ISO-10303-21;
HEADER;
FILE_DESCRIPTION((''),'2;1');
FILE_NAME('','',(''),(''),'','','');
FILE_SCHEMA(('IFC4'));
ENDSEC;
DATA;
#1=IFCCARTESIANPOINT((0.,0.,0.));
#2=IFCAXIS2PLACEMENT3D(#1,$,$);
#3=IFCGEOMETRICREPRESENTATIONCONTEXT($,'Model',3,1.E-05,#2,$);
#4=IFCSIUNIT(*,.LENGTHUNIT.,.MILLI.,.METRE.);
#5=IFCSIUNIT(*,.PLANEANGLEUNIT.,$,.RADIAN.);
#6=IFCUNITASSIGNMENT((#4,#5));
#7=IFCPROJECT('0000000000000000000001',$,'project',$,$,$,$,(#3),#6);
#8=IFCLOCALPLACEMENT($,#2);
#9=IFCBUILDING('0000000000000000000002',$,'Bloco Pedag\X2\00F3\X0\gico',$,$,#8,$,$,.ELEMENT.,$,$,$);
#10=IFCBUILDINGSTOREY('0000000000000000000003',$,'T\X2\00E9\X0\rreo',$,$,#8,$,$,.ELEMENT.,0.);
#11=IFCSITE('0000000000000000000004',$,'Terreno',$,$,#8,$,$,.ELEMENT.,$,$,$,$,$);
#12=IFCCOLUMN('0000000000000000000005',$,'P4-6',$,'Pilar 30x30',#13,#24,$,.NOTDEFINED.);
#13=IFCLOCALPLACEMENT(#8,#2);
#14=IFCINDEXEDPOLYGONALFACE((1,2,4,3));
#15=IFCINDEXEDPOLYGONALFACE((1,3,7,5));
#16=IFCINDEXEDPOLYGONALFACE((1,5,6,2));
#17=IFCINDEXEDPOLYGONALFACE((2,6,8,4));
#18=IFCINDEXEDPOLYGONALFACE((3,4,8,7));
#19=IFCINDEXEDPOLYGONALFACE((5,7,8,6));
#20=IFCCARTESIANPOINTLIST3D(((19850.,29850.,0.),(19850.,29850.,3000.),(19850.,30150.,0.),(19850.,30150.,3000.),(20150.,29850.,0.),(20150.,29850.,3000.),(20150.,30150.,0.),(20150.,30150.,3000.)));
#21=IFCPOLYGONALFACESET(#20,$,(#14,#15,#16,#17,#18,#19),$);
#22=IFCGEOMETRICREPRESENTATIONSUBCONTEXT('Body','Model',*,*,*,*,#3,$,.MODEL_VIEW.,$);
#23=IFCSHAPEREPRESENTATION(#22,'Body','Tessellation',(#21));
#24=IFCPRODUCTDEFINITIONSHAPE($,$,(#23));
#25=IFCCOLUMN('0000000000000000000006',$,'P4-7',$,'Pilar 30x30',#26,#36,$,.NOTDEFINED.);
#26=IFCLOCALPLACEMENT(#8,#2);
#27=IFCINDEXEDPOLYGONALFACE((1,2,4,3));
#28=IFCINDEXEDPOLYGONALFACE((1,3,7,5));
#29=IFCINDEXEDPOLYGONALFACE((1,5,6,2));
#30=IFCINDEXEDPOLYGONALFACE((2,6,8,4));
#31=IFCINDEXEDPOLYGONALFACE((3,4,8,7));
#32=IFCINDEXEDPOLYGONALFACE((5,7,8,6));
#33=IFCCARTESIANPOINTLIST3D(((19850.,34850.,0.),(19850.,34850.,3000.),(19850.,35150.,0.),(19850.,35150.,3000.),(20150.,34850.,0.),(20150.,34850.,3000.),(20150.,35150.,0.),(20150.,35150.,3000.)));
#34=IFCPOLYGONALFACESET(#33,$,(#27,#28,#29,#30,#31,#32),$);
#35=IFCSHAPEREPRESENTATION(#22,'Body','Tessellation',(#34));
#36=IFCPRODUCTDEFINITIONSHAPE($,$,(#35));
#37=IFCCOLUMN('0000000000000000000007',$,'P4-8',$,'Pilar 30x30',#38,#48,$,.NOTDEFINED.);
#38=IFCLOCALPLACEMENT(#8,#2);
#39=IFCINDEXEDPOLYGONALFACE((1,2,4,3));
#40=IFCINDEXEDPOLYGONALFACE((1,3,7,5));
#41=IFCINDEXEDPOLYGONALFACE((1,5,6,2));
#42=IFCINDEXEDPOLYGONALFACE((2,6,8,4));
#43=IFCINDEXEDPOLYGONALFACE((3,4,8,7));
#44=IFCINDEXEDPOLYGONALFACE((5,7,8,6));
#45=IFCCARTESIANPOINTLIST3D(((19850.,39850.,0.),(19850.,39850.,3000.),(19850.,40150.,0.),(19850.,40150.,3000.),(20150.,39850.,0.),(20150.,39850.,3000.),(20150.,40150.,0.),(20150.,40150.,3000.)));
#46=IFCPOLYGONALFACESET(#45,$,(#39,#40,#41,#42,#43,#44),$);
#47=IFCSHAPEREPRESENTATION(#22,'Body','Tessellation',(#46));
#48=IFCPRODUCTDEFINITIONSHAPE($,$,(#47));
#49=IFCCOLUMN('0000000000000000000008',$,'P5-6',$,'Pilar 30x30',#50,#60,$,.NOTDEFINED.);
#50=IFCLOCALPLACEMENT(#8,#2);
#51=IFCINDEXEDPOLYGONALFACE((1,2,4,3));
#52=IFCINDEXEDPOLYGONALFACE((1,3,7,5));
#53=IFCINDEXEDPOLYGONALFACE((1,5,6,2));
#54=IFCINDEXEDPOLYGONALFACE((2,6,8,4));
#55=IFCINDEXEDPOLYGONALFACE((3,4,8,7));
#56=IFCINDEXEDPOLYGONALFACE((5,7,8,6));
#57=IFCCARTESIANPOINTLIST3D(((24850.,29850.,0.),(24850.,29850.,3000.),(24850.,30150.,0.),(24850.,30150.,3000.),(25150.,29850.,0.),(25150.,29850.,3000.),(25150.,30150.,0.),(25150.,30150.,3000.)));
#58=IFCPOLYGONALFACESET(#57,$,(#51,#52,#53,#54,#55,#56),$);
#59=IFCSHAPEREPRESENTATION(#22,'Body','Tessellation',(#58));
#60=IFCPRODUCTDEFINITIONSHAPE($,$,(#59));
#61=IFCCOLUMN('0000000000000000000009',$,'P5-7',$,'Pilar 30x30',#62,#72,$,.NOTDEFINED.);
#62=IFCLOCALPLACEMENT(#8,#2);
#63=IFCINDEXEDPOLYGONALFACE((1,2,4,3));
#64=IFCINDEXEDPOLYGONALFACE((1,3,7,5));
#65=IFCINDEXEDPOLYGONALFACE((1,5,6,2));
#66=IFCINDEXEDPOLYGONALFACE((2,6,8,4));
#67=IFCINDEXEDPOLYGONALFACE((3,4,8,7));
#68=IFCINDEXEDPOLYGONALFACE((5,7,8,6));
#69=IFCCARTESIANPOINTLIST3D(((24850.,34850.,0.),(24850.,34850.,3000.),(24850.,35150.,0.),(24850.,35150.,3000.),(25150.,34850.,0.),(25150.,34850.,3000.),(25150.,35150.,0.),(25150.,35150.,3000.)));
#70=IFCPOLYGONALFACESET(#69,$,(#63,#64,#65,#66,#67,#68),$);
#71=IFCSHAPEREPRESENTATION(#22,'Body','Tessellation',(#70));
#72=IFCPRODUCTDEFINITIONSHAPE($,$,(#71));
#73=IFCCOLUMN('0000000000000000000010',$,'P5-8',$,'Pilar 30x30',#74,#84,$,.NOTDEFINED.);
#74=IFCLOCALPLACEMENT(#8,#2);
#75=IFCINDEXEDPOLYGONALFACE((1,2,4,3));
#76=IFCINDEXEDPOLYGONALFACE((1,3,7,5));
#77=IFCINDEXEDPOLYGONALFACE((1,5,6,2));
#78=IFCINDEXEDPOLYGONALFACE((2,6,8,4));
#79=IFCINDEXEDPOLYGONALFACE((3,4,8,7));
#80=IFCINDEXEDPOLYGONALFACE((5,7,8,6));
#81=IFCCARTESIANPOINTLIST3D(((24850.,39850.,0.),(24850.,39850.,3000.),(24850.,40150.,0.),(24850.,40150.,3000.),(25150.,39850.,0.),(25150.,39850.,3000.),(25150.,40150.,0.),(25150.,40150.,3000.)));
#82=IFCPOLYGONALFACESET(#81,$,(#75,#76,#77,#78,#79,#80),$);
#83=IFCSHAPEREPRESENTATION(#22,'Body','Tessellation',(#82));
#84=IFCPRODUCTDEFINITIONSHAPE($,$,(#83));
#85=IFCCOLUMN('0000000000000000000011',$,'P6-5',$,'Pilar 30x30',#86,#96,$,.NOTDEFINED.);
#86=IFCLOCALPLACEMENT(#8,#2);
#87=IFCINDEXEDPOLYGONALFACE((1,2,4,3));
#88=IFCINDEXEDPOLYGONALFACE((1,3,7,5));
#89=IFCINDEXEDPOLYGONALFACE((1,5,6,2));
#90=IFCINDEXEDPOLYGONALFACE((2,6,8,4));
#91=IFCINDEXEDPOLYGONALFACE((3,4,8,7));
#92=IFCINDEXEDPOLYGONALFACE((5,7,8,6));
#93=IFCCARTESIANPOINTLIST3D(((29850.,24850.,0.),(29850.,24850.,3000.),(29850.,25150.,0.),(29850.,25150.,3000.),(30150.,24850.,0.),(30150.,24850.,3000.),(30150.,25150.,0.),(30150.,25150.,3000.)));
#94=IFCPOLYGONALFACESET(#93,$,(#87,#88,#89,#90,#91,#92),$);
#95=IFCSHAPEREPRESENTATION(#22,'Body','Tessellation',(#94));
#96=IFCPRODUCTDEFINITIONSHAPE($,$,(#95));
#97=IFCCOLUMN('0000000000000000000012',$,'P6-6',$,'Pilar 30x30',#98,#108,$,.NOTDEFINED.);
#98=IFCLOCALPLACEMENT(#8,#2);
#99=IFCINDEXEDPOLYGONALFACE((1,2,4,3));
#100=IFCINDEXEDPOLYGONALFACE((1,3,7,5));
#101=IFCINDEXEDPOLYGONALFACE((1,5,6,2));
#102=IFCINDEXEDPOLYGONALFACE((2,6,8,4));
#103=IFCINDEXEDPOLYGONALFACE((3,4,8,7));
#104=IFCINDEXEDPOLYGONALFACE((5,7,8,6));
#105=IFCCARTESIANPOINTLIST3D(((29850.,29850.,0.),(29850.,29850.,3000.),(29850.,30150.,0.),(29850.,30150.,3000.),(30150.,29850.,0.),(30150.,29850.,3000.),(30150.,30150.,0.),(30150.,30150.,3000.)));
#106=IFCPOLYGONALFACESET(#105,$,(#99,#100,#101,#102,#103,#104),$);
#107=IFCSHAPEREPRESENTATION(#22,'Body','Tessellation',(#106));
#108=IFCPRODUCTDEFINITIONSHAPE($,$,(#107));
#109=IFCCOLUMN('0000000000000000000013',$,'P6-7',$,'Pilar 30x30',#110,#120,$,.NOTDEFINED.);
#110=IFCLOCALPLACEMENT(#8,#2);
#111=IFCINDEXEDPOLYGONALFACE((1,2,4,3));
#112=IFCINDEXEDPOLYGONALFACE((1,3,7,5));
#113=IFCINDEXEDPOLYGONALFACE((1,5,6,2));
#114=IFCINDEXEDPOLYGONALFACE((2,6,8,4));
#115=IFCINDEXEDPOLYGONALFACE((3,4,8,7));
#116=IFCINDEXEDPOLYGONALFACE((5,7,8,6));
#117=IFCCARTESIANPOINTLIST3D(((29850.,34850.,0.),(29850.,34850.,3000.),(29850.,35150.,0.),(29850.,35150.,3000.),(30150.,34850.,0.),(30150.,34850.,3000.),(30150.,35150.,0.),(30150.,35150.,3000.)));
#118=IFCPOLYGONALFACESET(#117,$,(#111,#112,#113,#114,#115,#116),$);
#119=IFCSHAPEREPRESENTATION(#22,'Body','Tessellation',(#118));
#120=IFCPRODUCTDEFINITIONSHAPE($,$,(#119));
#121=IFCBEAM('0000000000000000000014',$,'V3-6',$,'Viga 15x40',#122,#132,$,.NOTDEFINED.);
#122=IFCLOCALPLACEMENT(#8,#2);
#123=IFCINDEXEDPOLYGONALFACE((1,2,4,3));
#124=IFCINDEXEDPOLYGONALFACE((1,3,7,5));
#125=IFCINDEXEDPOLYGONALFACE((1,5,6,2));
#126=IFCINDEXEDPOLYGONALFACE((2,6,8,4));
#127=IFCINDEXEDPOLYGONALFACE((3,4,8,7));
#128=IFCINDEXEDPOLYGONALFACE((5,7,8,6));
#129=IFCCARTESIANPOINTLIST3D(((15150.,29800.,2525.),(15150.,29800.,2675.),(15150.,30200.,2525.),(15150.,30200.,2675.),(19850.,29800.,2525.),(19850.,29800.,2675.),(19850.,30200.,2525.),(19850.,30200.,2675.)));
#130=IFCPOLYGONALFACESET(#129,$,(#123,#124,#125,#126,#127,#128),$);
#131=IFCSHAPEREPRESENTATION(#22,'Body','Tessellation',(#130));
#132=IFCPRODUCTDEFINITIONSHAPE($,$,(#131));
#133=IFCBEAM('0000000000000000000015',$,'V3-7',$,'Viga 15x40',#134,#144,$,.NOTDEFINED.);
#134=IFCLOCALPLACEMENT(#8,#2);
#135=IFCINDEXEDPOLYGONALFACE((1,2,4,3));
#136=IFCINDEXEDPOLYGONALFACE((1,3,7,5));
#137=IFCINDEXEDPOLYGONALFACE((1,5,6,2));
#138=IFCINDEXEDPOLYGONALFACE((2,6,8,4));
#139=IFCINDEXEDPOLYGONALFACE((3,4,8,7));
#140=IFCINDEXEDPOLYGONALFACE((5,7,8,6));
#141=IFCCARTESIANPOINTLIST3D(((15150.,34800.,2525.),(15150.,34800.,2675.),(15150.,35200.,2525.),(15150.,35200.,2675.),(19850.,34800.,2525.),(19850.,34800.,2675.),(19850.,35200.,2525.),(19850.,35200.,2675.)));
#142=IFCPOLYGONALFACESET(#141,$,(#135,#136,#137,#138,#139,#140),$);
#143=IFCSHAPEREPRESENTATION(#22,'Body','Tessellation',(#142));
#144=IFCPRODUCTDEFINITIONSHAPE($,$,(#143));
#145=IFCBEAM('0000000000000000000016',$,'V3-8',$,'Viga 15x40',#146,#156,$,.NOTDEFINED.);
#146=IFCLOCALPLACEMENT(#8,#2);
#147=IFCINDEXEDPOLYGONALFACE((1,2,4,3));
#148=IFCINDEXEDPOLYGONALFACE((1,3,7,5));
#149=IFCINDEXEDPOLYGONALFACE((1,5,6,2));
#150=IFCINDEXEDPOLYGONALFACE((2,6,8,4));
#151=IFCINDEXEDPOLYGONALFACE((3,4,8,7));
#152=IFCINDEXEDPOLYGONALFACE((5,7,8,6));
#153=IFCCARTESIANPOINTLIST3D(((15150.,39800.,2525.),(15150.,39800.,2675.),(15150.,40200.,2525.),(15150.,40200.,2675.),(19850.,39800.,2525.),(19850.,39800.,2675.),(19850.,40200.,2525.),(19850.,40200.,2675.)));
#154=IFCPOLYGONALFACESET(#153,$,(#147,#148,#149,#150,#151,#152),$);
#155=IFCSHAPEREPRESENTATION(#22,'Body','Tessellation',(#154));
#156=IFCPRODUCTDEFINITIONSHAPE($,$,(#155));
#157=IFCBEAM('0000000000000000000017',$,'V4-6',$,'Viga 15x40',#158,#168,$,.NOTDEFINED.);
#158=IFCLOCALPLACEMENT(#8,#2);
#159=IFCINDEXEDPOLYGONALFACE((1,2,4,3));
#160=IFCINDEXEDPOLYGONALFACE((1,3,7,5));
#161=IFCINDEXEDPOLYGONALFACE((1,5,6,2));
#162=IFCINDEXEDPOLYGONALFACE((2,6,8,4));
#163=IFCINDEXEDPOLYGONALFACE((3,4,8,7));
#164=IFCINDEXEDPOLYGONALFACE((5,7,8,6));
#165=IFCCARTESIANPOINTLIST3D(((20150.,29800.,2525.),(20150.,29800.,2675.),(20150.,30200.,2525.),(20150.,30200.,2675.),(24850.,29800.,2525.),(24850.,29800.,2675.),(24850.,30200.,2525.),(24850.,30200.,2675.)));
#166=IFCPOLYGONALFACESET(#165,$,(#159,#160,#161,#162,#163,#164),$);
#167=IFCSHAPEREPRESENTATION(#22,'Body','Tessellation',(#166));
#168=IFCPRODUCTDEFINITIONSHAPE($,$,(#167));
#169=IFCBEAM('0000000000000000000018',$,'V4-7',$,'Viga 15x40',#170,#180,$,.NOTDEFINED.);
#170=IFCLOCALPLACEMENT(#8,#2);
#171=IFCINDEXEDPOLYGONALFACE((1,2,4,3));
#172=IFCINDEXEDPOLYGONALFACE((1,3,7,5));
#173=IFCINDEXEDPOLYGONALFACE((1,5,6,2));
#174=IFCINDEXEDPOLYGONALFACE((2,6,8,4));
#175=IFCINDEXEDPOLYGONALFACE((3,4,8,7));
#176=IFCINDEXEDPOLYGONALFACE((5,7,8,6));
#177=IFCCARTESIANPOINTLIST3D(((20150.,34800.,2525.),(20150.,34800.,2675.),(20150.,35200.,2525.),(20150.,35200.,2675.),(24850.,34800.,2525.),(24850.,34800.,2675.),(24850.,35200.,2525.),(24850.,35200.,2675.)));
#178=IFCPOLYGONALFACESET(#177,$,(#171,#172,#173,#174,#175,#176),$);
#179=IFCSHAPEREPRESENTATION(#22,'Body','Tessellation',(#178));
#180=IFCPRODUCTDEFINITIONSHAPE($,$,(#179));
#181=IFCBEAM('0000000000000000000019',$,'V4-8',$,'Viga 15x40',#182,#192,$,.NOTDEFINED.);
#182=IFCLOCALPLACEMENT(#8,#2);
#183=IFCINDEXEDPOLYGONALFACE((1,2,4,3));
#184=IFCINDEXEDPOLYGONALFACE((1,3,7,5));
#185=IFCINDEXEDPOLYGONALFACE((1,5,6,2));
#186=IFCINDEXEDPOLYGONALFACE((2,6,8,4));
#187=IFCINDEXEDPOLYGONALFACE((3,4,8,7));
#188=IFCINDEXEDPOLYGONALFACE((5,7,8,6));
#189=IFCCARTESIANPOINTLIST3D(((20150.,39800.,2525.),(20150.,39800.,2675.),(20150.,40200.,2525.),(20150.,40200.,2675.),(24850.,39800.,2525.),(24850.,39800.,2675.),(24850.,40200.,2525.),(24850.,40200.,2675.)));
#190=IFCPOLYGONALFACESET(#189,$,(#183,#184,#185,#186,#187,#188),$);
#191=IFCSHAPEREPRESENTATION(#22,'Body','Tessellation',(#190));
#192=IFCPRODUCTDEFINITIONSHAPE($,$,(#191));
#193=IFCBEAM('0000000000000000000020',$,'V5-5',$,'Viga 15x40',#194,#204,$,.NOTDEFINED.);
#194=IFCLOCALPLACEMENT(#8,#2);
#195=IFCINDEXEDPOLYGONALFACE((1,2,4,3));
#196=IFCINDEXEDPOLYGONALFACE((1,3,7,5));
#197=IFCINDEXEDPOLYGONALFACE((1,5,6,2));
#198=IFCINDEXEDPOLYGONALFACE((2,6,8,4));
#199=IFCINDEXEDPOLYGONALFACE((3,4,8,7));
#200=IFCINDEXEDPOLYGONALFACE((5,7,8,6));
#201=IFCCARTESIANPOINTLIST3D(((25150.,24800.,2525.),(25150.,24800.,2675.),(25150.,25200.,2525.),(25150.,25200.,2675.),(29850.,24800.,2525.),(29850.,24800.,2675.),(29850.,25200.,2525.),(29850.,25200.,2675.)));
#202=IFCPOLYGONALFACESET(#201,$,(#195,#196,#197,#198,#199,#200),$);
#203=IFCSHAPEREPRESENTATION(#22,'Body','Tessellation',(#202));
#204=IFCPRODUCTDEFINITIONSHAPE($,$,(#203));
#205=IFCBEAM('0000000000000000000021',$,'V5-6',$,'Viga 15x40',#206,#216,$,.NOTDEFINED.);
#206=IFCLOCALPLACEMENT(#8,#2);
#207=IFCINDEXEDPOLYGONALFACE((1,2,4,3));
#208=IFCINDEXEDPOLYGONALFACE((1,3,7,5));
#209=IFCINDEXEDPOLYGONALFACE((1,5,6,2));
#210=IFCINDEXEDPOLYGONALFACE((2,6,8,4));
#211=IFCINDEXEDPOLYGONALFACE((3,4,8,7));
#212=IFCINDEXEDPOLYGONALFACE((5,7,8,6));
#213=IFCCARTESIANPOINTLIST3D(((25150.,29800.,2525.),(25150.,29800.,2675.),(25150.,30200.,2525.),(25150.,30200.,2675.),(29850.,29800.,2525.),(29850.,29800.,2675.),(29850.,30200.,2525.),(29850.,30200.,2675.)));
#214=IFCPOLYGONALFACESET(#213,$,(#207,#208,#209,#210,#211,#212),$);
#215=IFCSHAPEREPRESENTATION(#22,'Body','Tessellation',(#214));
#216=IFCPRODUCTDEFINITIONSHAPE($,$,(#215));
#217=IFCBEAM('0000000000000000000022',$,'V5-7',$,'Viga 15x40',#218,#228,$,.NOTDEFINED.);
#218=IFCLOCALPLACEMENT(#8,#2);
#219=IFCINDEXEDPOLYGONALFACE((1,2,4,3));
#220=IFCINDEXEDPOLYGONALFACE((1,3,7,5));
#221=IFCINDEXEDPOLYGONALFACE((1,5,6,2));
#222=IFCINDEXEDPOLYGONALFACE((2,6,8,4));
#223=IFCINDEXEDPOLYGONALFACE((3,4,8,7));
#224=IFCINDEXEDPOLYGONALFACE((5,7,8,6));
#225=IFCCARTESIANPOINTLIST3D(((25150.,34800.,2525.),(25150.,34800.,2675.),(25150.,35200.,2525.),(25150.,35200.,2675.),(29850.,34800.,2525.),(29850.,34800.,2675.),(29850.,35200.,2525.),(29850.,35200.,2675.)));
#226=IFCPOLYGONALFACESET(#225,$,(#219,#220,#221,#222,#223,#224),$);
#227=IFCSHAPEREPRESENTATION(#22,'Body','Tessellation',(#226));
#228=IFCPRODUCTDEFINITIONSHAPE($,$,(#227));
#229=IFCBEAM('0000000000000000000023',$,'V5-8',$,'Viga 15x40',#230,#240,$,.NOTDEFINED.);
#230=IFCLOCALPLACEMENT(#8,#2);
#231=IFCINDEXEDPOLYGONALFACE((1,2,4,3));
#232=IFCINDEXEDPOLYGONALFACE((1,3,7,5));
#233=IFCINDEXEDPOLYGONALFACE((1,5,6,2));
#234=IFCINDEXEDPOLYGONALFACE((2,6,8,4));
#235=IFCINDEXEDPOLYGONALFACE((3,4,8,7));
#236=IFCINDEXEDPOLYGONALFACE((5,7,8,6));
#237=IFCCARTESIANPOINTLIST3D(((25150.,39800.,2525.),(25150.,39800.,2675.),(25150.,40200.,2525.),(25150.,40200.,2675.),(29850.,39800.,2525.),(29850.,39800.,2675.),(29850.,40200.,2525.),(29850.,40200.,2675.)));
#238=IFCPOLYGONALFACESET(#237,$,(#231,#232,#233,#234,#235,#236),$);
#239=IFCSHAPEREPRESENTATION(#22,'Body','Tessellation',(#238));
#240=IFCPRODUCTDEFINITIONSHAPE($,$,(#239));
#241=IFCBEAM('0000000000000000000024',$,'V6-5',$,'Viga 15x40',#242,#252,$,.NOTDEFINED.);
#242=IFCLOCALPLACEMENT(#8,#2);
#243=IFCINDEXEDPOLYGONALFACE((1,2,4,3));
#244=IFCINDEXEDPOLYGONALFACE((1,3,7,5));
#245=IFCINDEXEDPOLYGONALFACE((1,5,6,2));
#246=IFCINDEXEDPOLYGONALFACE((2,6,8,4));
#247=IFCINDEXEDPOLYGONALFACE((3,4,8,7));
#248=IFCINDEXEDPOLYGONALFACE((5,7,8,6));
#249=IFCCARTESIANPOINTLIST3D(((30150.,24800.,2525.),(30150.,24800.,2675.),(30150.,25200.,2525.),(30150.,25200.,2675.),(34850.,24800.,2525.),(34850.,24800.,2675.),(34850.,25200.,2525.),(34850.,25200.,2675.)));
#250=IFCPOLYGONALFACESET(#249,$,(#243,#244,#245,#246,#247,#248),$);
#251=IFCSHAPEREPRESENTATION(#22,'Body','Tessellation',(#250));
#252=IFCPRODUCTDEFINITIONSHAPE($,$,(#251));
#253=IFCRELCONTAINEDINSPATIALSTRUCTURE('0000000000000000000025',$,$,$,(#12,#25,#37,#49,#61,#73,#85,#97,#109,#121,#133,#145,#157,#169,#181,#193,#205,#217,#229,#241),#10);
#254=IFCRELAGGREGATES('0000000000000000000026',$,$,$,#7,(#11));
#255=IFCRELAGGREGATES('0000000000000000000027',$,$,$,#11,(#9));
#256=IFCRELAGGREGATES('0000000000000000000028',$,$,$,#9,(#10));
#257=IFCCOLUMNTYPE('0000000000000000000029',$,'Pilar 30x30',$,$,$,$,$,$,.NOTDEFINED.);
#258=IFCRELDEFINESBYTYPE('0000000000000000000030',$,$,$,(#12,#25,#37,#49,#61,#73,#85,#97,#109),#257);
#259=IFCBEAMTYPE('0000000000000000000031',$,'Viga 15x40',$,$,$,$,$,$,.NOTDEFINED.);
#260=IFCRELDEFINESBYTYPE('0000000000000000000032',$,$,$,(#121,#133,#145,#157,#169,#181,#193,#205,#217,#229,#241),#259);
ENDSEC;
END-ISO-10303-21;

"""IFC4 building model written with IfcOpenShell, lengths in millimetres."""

from ifc_helpers import new_model, si_unit, frame, origin, origin_2d, place, context, subcontext, project, spatial, rectangle, extrude, type_object, element, save


model = new_model("IFC4")

# Units and contexts
model_context = context("Model", 3, precision=1e-05, world=origin())
body_context = subcontext(model_context, "Body", "Model", "MODEL_VIEW")
ifc_project = project(units=[si_unit("LENGTHUNIT", "METRE", prefix="MILLI"), si_unit("PLANEANGLEUNIT", "RADIAN")], contexts=[model_context])

# Site, building, storey
placement = place(None, origin())
site = spatial("IfcSite", under=ifc_project, at=placement, Name="Terreno", CompositionType="ELEMENT")
building = spatial("IfcBuilding", under=site, at=placement, Name="Bloco Pedagógico", CompositionType="ELEMENT")
storey = spatial("IfcBuildingStorey", under=building, at=placement, Name="Térreo", CompositionType="ELEMENT", Elevation=0.0)

# Columns
column_type = type_object("IfcColumnType", Name="Pilar 30x30", PredefinedType="NOTDEFINED")
for number, where, z_axis, x_axis, name in (
    (1, (20000.0, 30000.0, 0.0), (0.0, 0.0, 1.0), (1.0, 0.0, 0.0), "P4-6"),
    (2, (20000.0, 35000.0, 0.0), (0.0, 0.0, 1.0), (1.0, 0.0, 0.0), "P4-7"),
    (3, (20000.0, 40000.0, 0.0), (0.0, 0.0, 1.0), (1.0, 0.0, 0.0), "P4-8"),
    (4, (25000.0, 30000.0, 0.0), (0.0, 0.0, 1.0), (1.0, 0.0, 0.0), "P5-6"),
    (5, (25000.0, 35000.0, 0.0), (0.0, 0.0, 1.0), (1.0, 0.0, 0.0), "P5-7"),
    (6, (25000.0, 40000.0, 0.0), (0.0, 0.0, 1.0), (1.0, 0.0, 0.0), "P5-8"),
    (7, (30000.0, 25000.0, 0.0), (0.0, 0.0, 1.0), (1.0, 0.0, 0.0), "P6-5"),
    (8, (30000.0, 30000.0, 0.0), (0.0, 0.0, 1.0), (1.0, 0.0, 0.0), "P6-6"),
    (9, (30000.0, 35000.0, 0.0), (0.0, 0.0, 1.0), (1.0, 0.0, 0.0), "P6-7"),
):
    element("IfcColumn", number, at=place(None, frame(where, z_axis=z_axis, x_axis=x_axis)), inside=storey, type_object=column_type, Name=name, ObjectType="Pilar 30x30", PredefinedType="NOTDEFINED", context=body_context, shape_type="SweptSolid", body=[
        extrude(rectangle(XDim=300.0, YDim=300.0, at=origin_2d()), None, (0.0, 0.0, 1.0), 3000.0),
    ])

# Beams
beam_type = type_object("IfcBeamType", Name="Viga 15x40", PredefinedType="NOTDEFINED")
for number, where, z_axis, x_axis, name in (
    (10, (15150.0, 30000.0, 2600.0), (1.0, 0.0, 0.0), (0.0, 1.0, 0.0), "V3-6"),
    (11, (15150.0, 35000.0, 2600.0), (1.0, 0.0, 0.0), (0.0, 1.0, 0.0), "V3-7"),
    (12, (15150.0, 40000.0, 2600.0), (1.0, 0.0, 0.0), (0.0, 1.0, 0.0), "V3-8"),
    (13, (20150.0, 30000.0, 2600.0), (1.0, 0.0, 0.0), (0.0, 1.0, 0.0), "V4-6"),
    (14, (20150.0, 35000.0, 2600.0), (1.0, 0.0, 0.0), (0.0, 1.0, 0.0), "V4-7"),
    (15, (20150.0, 40000.0, 2600.0), (1.0, 0.0, 0.0), (0.0, 1.0, 0.0), "V4-8"),
    (16, (25150.0, 25000.0, 2600.0), (1.0, 0.0, 0.0), (0.0, 1.0, 0.0), "V5-5"),
    (17, (25150.0, 30000.0, 2600.0), (1.0, 0.0, 0.0), (0.0, 1.0, 0.0), "V5-6"),
    (18, (25150.0, 35000.0, 2600.0), (1.0, 0.0, 0.0), (0.0, 1.0, 0.0), "V5-7"),
    (19, (25150.0, 40000.0, 2600.0), (1.0, 0.0, 0.0), (0.0, 1.0, 0.0), "V5-8"),
    (20, (30150.0, 25000.0, 2600.0), (1.0, 0.0, 0.0), (0.0, 1.0, 0.0), "V6-5"),
):
    element("IfcBeam", number, at=place(None, frame(where, z_axis=z_axis, x_axis=x_axis)), inside=storey, type_object=beam_type, Name=name, ObjectType="Viga 15x40", PredefinedType="NOTDEFINED", context=body_context, shape_type="SweptSolid", body=[
        extrude(rectangle(XDim=400.0, YDim=150.0, at=origin_2d()), None, (0.0, 0.0, 1.0), 4700.0),
    ])

save(model, "model.ifc")
